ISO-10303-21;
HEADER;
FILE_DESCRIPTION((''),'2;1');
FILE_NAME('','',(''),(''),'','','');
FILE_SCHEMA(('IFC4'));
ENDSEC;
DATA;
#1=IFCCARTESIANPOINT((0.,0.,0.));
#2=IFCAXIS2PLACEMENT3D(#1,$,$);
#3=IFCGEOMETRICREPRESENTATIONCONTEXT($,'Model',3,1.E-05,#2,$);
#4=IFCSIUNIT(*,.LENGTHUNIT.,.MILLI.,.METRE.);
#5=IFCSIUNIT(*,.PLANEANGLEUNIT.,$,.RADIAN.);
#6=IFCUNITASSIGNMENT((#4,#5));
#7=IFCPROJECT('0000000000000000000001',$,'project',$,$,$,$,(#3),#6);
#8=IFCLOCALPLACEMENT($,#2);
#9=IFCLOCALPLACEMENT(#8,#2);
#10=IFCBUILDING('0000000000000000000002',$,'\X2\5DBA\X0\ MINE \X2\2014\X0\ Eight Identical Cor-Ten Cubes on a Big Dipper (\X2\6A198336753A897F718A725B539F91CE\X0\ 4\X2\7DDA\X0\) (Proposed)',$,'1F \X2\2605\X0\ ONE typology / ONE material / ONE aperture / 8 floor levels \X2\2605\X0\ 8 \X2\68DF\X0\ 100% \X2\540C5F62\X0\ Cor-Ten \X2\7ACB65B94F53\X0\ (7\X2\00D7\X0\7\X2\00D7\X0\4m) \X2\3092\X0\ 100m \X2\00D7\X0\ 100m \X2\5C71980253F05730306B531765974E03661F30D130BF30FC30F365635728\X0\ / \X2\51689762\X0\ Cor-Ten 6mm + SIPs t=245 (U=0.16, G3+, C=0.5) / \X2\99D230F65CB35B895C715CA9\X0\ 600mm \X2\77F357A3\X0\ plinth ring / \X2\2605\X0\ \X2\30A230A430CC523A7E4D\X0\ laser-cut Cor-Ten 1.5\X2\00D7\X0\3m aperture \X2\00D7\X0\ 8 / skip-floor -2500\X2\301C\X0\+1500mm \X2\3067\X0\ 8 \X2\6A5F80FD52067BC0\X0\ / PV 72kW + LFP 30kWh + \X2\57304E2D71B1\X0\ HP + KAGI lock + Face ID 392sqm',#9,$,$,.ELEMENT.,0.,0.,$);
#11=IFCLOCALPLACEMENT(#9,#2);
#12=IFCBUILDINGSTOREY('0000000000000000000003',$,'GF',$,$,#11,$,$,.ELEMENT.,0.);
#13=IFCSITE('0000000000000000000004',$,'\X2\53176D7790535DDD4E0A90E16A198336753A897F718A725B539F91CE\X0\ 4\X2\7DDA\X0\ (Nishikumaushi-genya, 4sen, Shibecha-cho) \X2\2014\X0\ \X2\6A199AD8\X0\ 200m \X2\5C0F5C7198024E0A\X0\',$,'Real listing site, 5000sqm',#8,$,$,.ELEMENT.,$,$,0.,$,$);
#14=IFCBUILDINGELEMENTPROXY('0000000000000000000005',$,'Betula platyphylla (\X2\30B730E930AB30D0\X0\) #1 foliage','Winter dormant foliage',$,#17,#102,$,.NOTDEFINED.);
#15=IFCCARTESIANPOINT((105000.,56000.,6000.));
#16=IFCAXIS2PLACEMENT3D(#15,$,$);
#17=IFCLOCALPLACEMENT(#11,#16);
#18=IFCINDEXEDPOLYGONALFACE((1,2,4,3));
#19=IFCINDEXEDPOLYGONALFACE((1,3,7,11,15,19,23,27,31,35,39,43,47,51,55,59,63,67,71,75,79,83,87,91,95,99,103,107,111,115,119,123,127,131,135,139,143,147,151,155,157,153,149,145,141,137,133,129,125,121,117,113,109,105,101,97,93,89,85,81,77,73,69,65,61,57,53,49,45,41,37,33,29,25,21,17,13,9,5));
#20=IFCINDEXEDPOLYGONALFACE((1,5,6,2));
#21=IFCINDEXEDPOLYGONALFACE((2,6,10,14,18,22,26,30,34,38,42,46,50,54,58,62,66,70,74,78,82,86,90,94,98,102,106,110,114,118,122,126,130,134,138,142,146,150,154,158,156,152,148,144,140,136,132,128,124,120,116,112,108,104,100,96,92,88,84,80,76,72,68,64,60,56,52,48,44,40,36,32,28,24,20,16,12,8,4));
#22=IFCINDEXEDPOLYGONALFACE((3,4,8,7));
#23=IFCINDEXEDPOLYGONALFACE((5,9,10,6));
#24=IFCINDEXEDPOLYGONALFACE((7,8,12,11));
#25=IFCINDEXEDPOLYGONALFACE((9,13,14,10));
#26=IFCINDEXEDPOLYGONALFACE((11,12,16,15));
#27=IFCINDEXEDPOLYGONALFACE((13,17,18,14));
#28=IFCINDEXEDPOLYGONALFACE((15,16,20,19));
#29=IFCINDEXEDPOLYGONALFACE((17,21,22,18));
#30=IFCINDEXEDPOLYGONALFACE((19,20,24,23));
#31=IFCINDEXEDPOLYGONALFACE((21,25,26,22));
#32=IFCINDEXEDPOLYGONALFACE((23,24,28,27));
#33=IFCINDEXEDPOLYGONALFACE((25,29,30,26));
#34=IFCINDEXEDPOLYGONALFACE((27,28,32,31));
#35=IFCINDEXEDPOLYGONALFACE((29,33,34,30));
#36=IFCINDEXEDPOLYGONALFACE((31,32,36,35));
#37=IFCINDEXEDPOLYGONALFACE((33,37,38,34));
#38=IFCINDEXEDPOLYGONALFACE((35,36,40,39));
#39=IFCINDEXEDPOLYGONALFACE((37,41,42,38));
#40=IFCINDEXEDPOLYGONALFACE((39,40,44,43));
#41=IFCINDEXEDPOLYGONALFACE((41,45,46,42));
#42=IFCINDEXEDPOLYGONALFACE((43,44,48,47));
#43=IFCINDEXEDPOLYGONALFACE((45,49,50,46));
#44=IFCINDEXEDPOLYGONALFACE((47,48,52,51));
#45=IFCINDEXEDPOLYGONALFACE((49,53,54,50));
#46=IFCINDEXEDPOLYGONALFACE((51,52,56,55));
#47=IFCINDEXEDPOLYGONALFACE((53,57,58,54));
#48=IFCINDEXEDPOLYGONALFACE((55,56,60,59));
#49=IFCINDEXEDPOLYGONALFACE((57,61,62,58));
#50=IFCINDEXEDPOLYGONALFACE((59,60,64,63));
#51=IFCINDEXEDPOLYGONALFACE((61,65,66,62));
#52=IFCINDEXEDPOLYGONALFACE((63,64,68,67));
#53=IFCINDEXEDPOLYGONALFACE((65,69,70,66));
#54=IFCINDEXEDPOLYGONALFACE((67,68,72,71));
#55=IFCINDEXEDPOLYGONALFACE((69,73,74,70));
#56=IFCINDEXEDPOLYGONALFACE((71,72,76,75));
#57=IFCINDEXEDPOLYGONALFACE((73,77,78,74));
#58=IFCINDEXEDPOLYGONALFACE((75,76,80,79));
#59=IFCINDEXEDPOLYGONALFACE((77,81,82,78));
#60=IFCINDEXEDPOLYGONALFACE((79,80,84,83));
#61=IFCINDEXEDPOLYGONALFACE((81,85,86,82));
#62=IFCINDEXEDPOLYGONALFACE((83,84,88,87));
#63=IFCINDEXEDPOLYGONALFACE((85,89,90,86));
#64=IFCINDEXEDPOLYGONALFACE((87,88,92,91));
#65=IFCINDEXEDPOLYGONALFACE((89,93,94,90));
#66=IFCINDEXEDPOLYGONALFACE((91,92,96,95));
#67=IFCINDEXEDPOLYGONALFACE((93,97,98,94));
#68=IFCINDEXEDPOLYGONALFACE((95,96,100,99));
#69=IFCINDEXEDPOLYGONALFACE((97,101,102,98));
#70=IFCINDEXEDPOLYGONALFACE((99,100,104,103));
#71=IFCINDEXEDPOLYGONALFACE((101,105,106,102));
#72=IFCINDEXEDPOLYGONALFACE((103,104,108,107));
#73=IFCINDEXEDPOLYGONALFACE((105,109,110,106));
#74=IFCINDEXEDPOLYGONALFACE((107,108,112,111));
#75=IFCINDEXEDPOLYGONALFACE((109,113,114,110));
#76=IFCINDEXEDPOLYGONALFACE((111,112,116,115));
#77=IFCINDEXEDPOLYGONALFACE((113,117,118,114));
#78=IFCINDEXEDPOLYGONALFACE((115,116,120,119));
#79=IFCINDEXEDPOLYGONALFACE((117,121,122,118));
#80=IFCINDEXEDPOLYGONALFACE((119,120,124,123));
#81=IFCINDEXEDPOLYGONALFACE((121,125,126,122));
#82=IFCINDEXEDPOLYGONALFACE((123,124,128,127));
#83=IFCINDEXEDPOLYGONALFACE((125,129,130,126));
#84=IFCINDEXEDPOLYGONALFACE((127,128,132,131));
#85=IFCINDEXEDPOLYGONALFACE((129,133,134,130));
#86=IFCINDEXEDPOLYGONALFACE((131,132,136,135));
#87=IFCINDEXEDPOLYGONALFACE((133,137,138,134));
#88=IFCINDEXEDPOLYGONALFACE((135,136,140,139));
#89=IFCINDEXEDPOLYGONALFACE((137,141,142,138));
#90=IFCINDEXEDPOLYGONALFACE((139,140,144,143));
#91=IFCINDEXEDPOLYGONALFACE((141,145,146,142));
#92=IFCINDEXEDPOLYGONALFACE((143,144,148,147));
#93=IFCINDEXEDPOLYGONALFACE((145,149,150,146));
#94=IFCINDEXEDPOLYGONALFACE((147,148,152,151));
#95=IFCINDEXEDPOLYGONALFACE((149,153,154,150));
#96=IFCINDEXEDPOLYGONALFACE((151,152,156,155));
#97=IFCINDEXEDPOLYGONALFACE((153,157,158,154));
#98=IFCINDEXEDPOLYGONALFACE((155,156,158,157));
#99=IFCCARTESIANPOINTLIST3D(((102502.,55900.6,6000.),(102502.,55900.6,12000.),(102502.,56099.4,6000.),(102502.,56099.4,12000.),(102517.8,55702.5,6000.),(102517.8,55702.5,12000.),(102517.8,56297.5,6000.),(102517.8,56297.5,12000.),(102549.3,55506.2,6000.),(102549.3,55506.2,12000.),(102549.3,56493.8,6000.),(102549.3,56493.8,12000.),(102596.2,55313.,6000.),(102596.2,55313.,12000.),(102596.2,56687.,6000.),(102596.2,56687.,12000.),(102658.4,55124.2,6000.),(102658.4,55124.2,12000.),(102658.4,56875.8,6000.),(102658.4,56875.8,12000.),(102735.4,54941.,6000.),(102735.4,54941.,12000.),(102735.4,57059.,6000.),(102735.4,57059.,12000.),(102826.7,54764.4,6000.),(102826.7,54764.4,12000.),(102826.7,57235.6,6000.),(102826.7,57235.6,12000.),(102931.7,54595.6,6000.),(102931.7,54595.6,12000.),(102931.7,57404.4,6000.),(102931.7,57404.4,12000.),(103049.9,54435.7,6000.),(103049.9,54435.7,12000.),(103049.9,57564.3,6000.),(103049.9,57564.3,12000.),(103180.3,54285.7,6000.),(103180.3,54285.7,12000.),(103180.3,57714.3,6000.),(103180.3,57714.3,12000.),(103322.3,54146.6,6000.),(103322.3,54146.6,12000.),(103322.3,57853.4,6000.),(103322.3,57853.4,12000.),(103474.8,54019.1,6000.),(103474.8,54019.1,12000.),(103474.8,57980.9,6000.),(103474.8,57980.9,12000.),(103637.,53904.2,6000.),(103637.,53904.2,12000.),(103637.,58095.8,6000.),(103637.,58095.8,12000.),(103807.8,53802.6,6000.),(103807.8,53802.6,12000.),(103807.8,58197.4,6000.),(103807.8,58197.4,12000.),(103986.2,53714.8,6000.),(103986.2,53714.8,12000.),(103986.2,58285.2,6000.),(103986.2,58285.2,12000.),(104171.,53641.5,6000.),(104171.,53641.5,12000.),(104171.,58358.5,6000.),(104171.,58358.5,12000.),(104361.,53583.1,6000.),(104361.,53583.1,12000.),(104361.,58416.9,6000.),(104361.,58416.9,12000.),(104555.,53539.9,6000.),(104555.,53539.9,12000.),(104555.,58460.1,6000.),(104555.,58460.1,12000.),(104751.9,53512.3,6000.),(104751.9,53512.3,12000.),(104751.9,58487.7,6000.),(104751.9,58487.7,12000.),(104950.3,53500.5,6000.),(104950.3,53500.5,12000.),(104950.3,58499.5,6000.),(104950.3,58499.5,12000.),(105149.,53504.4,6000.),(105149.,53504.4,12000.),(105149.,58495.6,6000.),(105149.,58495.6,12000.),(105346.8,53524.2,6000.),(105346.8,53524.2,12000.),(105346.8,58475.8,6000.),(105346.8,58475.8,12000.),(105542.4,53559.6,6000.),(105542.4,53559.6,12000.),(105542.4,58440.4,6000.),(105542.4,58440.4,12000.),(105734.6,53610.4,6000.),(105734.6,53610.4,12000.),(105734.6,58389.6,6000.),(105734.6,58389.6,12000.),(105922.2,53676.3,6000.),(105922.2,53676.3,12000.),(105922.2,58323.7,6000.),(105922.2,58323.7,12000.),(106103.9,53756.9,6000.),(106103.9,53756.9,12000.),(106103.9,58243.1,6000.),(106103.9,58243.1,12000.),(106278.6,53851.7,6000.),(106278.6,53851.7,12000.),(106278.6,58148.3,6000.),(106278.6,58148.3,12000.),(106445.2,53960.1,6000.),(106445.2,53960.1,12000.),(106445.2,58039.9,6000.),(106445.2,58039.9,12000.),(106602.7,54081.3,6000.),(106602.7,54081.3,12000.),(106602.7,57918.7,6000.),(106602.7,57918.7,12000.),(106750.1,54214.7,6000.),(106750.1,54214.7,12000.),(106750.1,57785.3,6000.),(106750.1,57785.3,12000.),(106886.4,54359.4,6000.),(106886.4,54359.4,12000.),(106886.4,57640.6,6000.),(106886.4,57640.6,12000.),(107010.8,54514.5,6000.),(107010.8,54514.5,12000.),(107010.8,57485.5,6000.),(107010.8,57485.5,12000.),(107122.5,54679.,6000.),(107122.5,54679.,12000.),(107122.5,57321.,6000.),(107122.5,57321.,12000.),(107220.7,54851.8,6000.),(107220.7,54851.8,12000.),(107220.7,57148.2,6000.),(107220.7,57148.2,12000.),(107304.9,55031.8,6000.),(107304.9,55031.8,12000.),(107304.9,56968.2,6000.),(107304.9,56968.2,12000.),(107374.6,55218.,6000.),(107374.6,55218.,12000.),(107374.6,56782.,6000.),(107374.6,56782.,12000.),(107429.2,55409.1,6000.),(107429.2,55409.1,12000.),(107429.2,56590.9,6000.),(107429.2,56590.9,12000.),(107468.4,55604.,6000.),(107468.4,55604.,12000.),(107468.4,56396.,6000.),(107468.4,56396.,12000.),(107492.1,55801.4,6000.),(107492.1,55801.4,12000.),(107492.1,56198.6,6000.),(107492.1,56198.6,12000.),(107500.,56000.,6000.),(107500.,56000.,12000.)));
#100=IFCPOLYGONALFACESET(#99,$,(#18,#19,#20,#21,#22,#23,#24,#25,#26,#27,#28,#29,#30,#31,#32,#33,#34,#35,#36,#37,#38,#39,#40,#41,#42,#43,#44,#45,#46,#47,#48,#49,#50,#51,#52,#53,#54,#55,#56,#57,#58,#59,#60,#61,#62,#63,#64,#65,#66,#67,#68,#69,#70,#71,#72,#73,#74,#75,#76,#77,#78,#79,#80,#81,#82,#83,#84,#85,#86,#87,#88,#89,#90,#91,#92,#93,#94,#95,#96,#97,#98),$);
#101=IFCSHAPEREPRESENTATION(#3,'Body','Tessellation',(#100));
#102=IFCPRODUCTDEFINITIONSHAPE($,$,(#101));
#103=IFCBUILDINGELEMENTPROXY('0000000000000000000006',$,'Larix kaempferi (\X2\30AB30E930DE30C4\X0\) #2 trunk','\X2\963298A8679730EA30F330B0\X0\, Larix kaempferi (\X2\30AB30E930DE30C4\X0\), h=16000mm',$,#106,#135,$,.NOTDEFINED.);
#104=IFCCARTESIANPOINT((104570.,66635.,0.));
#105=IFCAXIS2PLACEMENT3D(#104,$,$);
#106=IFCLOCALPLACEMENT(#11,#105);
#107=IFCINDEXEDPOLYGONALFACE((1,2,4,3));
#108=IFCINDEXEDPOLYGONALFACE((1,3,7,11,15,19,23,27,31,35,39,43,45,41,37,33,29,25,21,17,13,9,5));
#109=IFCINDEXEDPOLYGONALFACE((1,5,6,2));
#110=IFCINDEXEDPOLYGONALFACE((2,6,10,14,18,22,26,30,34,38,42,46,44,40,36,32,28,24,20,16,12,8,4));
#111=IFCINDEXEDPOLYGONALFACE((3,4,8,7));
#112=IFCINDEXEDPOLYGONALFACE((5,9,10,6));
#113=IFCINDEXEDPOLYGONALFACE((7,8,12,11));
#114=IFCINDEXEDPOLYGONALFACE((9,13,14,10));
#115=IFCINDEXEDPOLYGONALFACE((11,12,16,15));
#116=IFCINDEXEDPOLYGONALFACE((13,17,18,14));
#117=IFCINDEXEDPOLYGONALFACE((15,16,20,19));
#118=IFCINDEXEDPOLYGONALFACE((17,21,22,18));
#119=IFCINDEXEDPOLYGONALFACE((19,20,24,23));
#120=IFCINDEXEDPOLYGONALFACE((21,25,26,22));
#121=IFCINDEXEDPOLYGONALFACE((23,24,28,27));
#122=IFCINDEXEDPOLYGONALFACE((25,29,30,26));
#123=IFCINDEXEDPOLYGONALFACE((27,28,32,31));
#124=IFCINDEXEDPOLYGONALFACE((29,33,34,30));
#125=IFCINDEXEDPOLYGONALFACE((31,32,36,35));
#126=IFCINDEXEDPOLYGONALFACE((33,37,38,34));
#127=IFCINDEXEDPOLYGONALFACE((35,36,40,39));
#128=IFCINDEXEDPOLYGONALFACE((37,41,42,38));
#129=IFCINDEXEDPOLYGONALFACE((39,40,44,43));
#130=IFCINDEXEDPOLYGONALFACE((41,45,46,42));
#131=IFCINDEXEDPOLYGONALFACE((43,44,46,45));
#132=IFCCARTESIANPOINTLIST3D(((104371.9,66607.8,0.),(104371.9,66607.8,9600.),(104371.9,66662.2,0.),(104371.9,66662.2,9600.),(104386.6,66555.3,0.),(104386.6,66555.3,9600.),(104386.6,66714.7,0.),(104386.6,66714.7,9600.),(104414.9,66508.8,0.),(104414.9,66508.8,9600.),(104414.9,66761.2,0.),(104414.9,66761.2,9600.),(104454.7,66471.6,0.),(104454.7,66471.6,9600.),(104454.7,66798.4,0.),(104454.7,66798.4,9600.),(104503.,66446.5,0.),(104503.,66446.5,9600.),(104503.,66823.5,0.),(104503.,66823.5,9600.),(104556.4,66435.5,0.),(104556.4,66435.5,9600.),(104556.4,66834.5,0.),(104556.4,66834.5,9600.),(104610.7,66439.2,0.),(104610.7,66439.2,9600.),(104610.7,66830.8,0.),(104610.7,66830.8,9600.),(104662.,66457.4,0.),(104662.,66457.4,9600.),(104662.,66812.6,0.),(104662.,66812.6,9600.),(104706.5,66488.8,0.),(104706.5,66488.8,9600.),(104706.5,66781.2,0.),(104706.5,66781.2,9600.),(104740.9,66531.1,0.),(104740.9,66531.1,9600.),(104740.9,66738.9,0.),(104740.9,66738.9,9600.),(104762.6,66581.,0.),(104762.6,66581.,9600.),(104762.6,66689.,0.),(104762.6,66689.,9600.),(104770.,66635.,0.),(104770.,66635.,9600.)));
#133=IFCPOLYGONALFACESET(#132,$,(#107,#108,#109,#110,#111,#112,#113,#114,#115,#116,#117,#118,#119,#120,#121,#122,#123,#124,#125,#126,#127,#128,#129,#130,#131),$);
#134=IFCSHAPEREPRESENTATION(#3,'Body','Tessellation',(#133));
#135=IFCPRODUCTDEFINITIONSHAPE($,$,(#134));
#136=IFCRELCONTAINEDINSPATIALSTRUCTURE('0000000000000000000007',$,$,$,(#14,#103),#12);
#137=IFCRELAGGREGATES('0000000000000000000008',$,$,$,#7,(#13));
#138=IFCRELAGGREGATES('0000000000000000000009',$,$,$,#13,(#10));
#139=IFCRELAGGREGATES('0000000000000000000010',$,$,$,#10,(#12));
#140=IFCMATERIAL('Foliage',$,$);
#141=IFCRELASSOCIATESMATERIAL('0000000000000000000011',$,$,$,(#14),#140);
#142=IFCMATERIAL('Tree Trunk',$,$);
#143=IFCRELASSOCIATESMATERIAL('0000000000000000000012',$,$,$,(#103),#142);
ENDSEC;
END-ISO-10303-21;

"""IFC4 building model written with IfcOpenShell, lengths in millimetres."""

from ifc_helpers import new_model, si_unit, frame, origin, origin_2d, place, context, project, spatial, circle, extrude, material, element, save


model = new_model("IFC4")

# Units and contexts
model_context = context("Model", 3, precision=1e-05, world=origin())
ifc_project = project(units=[si_unit("LENGTHUNIT", "METRE", prefix="MILLI"), si_unit("PLANEANGLEUNIT", "RADIAN")], contexts=[model_context])

# Site, building, storey
site_placement = place(None, origin())
site = spatial("IfcSite", under=ifc_project, at=site_placement, Name="北海道川上郡標茶町西熊牛原野 4線 (Nishikumaushi-genya, 4sen, Shibecha-cho) — 標高 200m 小山頂上", ObjectType="Real listing site, 5000sqm", CompositionType="ELEMENT", RefElevation=0.0)
building_placement = place(site_placement, origin())
building = spatial("IfcBuilding", under=site, at=building_placement, Name="嶺 MINE — Eight Identical Cor-Ten Cubes on a Big Dipper (標茶町西熊牛原野 4線) (Proposed)", ObjectType="1F ★ ONE typology / ONE material / ONE aperture / 8 floor levels ★ 8 棟 100% 同形 Cor-Ten 立方体 (7×7×4m) を 100m × 100m 山頂台地に北斗七星パターン散在 / 全面 Cor-Ten 6mm + SIPs t=245 (U=0.16, G3+, C=0.5) / 駒ヶ岳安山岩 600mm 石垣 plinth ring / ★ アイヌ刺繍 laser-cut Cor-Ten 1.5×3m aperture × 8 / skip-floor -2500〜+1500mm で 8 機能分節 / PV 72kW + LFP 30kWh + 地中熱 HP + KAGI lock + Face ID 392sqm", CompositionType="ELEMENT", ElevationOfRefHeight=0.0, ElevationOfTerrain=0.0)
storey_placement = place(building_placement, origin())
storey = spatial("IfcBuildingStorey", under=building, at=storey_placement, Name="GF", CompositionType="ELEMENT", Elevation=0.0)

# Building element proxies
ifc_material_1 = material(Name="Tree Trunk")
ifc_material_2 = material(Name="Foliage")
proxy_1_placement = place(storey_placement, frame((105000.0, 56000.0, 6000.0)))
element("IfcBuildingElementProxy", 1, at=proxy_1_placement, inside=storey, material=ifc_material_2, Name="Betula platyphylla (シラカバ) #1 foliage", Description="Winter dormant foliage", PredefinedType="NOTDEFINED", context=model_context, shape_type="SweptSolid", body=[
    extrude(circle(Radius=2500.0, at=origin_2d()), frame((105000.0, 56000.0, 6000.0)), (0.0, 0.0, 1.0), 6000.0),
])
proxy_2_placement = place(storey_placement, frame((104570.0, 66635.0, 0.0)))
element("IfcBuildingElementProxy", 2, at=proxy_2_placement, inside=storey, material=ifc_material_1, Name="Larix kaempferi (カラマツ) #2 trunk", Description="防風林リング, Larix kaempferi (カラマツ), h=16000mm", PredefinedType="NOTDEFINED", context=model_context, shape_type="SweptSolid", body=[
    extrude(circle(Radius=200.0, at=origin_2d()), frame((104570.0, 66635.0, 0.0)), (0.0, 0.0, 1.0), 9600.0),
])

save(model, "model.ifc")
